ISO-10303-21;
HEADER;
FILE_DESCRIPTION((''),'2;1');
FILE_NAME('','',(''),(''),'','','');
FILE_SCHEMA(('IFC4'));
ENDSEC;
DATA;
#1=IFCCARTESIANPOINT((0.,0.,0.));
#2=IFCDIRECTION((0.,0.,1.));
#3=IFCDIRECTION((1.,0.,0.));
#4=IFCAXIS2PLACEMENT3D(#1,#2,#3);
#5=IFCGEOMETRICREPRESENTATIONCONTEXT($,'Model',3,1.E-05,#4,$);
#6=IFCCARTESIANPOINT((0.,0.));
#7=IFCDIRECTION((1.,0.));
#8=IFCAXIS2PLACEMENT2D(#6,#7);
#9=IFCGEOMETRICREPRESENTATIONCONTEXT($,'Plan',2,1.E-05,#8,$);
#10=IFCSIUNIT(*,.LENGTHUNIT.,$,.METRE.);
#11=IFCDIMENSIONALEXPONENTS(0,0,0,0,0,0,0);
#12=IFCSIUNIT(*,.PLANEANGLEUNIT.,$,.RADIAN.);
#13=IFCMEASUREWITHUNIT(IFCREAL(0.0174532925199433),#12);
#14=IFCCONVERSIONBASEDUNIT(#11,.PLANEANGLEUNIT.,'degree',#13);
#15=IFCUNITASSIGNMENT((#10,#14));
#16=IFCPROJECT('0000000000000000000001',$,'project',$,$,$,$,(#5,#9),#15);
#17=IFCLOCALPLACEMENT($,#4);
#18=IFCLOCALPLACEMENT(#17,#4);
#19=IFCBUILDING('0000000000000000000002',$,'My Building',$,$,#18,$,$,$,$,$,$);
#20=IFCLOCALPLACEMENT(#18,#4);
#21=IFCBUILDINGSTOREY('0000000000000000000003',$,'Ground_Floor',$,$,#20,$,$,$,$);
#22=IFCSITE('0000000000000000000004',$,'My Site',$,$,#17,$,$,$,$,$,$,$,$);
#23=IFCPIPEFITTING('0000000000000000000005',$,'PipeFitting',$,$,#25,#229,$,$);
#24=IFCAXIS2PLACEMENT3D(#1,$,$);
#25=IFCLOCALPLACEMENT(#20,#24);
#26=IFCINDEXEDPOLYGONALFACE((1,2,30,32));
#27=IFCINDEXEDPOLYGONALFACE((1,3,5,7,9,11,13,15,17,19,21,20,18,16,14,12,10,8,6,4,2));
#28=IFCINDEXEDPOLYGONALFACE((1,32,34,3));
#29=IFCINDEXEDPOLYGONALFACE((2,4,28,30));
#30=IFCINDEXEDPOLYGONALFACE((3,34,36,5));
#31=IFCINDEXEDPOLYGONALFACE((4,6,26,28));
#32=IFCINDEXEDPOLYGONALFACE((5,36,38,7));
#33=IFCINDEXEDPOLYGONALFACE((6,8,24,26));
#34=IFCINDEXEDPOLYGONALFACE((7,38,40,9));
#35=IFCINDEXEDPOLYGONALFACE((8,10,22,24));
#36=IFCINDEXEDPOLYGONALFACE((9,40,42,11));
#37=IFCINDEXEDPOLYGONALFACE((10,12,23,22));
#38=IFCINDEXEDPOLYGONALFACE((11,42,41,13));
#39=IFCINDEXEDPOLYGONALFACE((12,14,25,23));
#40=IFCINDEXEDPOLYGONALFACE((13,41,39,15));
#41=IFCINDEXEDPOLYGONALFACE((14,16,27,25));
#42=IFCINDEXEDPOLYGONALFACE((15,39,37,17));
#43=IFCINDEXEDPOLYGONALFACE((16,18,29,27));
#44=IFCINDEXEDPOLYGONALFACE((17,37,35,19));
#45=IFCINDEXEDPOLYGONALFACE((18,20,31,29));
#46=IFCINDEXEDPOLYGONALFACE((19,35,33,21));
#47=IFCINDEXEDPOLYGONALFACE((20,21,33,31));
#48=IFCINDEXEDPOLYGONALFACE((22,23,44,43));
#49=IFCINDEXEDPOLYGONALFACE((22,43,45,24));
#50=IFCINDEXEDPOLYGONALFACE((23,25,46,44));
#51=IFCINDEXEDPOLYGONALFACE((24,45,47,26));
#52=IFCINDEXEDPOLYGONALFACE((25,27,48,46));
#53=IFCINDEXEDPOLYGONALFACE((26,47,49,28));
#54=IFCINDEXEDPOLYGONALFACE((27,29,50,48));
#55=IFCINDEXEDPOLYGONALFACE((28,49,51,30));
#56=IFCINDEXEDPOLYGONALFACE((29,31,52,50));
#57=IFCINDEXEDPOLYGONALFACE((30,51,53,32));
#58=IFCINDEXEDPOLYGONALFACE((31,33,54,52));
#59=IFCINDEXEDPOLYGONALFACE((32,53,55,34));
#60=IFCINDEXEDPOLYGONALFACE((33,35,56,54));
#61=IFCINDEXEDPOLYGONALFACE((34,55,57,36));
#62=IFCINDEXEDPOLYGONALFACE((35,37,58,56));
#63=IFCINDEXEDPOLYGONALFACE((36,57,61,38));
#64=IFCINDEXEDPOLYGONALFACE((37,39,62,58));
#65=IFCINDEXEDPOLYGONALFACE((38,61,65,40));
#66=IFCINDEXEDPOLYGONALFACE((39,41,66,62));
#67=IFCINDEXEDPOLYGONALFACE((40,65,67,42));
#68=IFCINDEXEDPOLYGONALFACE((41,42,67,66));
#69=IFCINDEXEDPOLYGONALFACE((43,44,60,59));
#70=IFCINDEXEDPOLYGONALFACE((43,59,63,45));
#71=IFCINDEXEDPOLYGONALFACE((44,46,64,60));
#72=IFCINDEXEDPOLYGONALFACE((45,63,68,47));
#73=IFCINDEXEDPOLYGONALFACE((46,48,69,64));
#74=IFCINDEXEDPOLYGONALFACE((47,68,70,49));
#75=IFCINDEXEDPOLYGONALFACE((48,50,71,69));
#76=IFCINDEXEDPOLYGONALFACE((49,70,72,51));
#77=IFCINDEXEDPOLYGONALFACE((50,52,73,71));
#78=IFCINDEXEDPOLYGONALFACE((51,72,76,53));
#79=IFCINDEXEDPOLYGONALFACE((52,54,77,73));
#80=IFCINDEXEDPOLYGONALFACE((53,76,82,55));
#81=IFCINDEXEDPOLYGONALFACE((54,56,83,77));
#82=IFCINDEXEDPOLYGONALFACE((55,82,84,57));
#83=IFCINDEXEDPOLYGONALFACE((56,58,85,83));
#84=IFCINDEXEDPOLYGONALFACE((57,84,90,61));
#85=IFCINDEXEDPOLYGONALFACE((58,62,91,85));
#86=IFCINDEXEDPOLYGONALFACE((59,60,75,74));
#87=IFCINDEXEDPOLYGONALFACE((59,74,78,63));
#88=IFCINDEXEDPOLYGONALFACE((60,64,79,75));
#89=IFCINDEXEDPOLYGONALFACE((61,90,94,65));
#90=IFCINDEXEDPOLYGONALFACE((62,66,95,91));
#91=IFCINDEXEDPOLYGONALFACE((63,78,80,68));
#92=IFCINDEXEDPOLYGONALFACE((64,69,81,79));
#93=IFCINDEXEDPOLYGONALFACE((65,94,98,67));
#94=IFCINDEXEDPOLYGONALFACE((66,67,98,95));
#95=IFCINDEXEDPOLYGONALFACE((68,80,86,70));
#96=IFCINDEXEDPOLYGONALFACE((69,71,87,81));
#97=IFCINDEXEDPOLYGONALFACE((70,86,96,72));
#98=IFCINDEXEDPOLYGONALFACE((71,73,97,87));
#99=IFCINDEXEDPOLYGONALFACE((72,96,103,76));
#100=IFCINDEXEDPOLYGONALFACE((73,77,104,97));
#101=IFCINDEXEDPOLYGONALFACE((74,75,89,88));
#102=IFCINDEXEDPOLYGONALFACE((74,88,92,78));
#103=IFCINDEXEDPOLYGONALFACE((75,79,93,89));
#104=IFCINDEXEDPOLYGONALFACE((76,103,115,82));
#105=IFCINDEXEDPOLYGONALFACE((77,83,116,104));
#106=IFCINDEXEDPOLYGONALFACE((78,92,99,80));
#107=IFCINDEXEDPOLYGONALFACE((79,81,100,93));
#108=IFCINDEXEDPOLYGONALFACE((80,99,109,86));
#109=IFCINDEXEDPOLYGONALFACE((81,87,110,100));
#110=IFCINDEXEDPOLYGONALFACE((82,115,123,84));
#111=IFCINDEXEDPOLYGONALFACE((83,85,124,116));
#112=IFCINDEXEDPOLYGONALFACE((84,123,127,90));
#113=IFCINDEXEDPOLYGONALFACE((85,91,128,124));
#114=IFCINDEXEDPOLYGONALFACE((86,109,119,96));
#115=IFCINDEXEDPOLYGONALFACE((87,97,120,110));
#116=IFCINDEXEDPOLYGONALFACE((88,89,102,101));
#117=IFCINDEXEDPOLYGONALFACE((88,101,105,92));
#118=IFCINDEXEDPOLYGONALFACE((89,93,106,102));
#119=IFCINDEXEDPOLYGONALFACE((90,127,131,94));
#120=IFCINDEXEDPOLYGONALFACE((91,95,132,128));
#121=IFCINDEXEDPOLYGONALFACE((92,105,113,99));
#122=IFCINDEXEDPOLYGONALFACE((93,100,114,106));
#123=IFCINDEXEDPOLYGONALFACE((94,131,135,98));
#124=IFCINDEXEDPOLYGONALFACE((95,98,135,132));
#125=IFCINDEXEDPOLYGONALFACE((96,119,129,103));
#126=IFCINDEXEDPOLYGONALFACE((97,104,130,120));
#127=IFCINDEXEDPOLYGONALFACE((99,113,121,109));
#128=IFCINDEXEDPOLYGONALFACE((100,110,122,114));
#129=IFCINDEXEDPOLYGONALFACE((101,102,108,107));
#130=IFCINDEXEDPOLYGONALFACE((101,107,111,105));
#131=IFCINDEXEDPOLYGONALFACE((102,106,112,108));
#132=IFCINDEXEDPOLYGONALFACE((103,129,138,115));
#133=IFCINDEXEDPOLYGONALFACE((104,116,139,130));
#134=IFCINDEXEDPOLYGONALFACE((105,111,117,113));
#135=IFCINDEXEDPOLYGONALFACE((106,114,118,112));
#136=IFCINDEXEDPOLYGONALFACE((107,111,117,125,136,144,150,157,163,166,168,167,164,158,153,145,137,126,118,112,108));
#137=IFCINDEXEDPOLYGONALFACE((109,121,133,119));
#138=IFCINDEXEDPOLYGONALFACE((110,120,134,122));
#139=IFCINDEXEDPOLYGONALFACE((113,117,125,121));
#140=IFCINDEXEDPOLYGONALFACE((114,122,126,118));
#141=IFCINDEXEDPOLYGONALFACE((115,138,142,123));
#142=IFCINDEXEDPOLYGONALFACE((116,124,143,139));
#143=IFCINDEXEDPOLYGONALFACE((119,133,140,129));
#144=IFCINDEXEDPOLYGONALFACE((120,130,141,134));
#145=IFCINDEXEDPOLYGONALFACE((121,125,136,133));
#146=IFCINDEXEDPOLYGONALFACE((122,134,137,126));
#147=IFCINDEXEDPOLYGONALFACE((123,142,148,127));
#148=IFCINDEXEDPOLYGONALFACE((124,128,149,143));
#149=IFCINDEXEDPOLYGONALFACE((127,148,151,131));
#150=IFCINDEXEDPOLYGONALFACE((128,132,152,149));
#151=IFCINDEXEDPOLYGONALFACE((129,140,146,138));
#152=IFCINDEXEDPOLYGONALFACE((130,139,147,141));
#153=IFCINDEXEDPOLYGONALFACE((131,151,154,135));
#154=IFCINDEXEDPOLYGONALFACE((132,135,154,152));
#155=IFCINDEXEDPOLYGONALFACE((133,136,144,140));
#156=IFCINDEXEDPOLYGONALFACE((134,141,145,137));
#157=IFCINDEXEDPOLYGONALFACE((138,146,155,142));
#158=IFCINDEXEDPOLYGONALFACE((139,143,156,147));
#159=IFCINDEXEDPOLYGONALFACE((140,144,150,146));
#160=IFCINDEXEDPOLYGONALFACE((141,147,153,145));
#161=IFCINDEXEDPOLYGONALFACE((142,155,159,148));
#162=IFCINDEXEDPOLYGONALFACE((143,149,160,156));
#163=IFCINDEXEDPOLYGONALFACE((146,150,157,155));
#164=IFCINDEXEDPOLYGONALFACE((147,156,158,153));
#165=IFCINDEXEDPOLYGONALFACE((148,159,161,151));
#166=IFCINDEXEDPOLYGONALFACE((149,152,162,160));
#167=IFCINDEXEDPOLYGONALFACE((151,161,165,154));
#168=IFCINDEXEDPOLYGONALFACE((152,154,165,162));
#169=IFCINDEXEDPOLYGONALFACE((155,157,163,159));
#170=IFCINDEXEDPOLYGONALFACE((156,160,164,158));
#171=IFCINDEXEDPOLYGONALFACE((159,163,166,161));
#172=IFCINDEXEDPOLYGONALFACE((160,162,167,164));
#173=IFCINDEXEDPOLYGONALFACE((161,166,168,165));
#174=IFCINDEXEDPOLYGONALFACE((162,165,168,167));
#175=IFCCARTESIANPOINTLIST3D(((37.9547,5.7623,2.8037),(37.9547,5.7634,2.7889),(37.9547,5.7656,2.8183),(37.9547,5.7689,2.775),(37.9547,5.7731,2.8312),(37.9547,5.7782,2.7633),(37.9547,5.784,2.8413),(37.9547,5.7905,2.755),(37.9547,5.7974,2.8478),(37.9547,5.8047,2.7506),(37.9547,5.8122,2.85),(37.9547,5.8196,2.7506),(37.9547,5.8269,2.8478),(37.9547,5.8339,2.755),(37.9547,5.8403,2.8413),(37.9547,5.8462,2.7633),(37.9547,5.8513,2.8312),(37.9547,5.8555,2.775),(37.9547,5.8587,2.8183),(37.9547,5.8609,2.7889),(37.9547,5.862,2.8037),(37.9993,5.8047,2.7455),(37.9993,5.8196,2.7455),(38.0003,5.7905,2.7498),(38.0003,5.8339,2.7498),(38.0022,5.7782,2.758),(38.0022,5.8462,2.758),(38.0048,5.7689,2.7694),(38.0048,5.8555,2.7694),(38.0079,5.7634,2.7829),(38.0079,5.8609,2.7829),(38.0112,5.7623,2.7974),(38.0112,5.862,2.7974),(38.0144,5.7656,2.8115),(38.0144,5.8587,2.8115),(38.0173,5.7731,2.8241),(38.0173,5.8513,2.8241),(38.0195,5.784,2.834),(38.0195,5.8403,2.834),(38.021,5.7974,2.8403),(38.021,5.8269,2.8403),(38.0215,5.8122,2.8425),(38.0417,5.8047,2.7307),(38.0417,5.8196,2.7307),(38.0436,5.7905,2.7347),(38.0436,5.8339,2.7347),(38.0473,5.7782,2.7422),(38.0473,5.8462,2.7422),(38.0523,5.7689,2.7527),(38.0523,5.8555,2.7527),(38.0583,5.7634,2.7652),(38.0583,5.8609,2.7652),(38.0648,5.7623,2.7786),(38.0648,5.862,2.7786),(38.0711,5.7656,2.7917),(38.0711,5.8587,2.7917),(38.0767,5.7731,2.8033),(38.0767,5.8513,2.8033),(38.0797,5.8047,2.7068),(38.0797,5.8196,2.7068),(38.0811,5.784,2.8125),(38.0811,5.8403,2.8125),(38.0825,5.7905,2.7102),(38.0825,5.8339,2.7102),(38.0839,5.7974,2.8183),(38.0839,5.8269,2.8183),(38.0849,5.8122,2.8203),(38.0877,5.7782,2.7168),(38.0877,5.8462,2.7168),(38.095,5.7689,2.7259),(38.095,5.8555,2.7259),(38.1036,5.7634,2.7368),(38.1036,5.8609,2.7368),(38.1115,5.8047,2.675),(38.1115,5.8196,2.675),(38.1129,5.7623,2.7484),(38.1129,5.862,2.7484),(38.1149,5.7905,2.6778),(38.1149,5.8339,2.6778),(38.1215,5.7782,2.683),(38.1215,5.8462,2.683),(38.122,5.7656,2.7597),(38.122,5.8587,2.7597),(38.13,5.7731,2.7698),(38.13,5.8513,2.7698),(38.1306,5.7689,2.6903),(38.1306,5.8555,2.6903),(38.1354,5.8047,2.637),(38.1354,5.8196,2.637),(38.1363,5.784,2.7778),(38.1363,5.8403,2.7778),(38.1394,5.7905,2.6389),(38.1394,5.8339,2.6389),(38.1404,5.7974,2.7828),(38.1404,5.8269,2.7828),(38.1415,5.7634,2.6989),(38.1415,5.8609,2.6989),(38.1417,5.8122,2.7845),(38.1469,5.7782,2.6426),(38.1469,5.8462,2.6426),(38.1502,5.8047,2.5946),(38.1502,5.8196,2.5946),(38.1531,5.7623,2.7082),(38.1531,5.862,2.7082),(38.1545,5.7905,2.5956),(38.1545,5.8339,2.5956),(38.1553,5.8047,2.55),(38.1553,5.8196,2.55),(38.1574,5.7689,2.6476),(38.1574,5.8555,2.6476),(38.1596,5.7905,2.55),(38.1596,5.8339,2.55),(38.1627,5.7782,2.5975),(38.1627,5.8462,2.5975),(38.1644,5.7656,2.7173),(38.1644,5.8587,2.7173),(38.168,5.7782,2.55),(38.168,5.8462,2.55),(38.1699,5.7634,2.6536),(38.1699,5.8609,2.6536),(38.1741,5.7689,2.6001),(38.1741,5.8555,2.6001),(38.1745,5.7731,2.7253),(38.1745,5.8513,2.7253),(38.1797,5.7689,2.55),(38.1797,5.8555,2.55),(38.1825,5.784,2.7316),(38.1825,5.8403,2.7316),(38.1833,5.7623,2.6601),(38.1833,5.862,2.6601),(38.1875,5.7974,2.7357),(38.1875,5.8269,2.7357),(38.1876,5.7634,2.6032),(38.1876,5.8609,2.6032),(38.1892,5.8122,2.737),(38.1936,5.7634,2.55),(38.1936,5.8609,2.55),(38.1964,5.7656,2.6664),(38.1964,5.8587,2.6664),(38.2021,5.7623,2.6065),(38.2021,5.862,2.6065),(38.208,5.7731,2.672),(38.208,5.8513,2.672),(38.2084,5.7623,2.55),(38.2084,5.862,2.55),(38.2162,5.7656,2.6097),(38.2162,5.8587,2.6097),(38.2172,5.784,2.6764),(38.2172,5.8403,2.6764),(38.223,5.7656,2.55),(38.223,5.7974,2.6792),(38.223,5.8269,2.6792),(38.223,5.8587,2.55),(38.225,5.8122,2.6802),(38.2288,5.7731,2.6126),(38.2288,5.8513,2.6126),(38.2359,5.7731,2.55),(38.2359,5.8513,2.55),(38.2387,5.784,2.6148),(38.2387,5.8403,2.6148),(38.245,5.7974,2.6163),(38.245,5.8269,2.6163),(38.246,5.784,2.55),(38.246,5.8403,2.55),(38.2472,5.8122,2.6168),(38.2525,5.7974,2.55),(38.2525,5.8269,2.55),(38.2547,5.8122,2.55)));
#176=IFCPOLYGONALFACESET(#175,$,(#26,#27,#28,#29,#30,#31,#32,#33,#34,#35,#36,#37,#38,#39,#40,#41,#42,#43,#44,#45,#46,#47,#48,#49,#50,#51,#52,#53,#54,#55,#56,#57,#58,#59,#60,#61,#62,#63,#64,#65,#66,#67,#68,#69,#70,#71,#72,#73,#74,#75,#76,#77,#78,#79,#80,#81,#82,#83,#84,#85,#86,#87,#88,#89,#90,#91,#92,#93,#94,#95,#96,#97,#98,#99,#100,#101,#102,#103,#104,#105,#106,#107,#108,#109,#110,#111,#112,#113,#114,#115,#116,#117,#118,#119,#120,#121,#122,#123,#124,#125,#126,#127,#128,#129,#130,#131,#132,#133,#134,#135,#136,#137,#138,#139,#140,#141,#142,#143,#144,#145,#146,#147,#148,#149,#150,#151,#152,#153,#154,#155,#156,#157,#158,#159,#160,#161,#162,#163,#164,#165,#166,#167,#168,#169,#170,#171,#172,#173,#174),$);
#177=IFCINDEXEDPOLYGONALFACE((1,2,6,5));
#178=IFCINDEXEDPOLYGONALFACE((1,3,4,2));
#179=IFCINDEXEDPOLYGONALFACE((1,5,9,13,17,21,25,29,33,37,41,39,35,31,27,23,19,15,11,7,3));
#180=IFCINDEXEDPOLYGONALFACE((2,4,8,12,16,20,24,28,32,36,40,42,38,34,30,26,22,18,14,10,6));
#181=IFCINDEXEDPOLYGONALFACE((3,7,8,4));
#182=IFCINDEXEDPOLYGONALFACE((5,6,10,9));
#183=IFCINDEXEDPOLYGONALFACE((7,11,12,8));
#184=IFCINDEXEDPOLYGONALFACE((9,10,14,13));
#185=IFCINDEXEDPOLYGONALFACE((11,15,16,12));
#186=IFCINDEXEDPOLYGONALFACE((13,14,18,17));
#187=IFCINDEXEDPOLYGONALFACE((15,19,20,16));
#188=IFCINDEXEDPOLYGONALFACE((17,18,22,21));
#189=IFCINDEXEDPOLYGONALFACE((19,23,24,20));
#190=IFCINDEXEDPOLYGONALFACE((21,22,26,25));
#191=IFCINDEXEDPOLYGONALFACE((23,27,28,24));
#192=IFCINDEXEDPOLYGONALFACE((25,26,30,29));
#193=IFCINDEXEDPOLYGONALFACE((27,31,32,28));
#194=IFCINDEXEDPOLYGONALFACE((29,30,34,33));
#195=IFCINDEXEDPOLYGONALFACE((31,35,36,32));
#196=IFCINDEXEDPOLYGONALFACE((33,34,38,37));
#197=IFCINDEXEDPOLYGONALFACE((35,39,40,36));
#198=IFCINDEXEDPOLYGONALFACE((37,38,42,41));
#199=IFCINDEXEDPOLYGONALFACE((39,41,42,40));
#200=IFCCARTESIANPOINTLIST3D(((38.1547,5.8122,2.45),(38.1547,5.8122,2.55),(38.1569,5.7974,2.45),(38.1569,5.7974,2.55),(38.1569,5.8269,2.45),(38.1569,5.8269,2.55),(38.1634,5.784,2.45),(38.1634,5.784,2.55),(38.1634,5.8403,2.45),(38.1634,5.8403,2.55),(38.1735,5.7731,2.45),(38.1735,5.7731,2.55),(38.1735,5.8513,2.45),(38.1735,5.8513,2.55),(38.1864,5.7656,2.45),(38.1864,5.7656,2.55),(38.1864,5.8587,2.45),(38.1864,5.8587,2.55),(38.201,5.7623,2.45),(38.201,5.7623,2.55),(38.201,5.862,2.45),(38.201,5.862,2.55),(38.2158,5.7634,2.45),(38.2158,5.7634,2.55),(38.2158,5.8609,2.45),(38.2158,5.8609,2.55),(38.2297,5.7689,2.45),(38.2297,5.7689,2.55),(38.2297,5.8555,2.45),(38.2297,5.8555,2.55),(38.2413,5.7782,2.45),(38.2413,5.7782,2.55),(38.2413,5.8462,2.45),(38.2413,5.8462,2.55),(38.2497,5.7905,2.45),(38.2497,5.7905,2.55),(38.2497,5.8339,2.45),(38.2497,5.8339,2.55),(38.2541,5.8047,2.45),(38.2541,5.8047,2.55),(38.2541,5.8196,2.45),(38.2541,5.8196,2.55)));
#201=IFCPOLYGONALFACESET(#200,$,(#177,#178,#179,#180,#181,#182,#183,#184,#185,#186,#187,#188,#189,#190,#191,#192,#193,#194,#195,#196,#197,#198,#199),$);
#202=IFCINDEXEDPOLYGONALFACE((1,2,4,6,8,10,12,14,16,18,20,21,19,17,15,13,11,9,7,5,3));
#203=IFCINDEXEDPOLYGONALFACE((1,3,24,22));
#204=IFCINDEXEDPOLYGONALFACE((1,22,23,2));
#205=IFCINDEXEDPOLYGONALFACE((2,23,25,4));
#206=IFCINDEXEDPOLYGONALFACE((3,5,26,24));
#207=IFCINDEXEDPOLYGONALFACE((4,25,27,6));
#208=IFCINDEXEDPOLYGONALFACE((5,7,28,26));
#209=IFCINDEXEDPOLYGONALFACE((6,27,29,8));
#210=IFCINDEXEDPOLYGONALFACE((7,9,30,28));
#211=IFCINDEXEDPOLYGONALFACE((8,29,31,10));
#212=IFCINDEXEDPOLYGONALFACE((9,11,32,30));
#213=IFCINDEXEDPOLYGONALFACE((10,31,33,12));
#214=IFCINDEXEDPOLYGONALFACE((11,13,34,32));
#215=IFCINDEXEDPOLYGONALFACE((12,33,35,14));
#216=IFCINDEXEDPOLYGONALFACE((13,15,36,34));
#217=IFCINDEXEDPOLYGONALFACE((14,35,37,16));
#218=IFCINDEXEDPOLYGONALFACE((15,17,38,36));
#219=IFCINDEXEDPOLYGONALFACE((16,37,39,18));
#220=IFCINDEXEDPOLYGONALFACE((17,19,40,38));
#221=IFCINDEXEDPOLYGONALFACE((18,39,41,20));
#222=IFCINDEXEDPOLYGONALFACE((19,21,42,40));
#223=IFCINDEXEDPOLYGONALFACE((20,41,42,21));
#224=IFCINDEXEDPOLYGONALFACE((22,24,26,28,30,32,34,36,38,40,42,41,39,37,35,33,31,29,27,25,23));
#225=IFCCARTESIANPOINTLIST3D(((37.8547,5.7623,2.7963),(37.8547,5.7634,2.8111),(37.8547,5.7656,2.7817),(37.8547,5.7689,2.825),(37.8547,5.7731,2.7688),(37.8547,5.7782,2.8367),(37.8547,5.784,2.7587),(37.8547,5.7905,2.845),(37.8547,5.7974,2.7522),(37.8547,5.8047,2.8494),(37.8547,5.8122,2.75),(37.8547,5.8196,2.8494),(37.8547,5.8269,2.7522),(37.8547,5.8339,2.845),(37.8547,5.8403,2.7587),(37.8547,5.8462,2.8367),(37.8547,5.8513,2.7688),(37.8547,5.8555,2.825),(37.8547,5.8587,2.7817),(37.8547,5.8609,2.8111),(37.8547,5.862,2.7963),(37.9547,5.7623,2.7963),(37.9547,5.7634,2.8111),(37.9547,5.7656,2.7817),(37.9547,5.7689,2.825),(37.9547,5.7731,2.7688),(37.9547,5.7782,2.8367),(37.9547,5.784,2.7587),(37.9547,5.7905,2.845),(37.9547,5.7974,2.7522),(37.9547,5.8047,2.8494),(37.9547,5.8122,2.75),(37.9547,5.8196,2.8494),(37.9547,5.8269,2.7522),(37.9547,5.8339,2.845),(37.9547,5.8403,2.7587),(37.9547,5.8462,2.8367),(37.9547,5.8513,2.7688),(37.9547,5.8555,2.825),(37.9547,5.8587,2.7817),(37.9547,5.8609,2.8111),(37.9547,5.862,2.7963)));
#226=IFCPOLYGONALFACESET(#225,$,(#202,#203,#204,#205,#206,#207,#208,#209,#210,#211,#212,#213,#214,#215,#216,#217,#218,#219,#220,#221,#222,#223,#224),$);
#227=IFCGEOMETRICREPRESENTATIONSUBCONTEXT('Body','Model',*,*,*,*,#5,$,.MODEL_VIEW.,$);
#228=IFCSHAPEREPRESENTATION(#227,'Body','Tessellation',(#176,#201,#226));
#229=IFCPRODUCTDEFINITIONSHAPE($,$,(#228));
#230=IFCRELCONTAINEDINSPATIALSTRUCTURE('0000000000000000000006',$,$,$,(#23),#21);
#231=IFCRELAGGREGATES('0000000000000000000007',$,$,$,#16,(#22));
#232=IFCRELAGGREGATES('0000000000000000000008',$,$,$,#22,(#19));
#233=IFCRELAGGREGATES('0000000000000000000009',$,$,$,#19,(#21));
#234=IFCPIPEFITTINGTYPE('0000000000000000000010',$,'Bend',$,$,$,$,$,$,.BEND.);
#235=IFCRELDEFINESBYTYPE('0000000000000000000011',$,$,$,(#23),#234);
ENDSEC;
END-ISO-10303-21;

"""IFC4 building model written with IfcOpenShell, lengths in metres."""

from ifc_helpers import new_model, entity, si_unit, converted_unit, frame, origin_with_axes, origin_2d_with_axis, place, context, subcontext, project, spatial, circle, extrude, source, transform, mapped, type_object, type_shapes, element, save


model = new_model("IFC4")

# Units and contexts
model_context = context("Model", 3, precision=1e-05, world=origin_with_axes())
plan_context = context("Plan", 2, precision=1e-05, world=origin_2d_with_axis())
body_context = subcontext(model_context, "Body", "Model", "MODEL_VIEW")
ifc_project = project(units=[si_unit("LENGTHUNIT", "METRE"), converted_unit("PLANEANGLEUNIT", "degree", entity("IfcReal", 0.0174532925199433), si_unit("PLANEANGLEUNIT", "RADIAN"), dimensions=[0, 0, 0, 0, 0, 0, 0])], contexts=[model_context, plan_context])

# Site, building, storey
site_placement = place(None, origin_with_axes())
site = spatial("IfcSite", under=ifc_project, at=site_placement, Name="My Site")
building_placement = place(site_placement, origin_with_axes())
building = spatial("IfcBuilding", under=site, at=building_placement, Name="My Building")
storey_placement = place(building_placement, origin_with_axes())
storey = spatial("IfcBuildingStorey", under=building, at=storey_placement, Name="Ground_Floor")

# Pipe fitting
pipe_fitting_type = type_object("IfcPipeFittingType", Name="Bend", PredefinedType="BEND")
shared_shape = source(origin_with_axes(), body_context, "Body", "SolidModel", [
    entity("IfcSweptDiskSolid", entity("IfcIndexedPolyCurve", entity("IfcCartesianPointList3D", [[0.0, 0.0, -0.1], [0.0732, 0.0, -0.2768], [0.25, 0.0, -0.35]]), [entity("IfcArcIndex", [1, 2, 3])]), 0.05),
    extrude(circle(Radius=0.05), origin_with_axes(), (0.0, 0.0, -1.0), 0.1),
    extrude(circle(Radius=0.05), frame((0.25, 0.0, -0.35), z_axis=(1.0, 0.0, 0.0), x_axis=(0.0, 0.0, 1.0)), (0.0, 0.0, 1.0), 0.1),
])
type_shapes(pipe_fitting_type, [shared_shape])
for number, where, z_axis, x_axis, name in (
    (1, (38.2047, 5.8122, 2.45), (0.0, 0.0, -1.0), (-1.0, 0.0, 0.0), "PipeFitting"),
):
    element("IfcPipeFitting", number, at=place(storey_placement, frame(where, z_axis=z_axis, x_axis=x_axis)), inside=storey, type_object=pipe_fitting_type, Name=name, context=body_context, shape_type="MappedRepresentation", body=[
        mapped(shared_shape, transform((0.0, 0.0, 0.0), x_axis=(1.0, 0.0, 0.0), y_axis=(0.0, 1.0, 0.0), z_axis=(0.0, 0.0, 1.0), scale=1.0)),
    ])

save(model, "model.ifc")
